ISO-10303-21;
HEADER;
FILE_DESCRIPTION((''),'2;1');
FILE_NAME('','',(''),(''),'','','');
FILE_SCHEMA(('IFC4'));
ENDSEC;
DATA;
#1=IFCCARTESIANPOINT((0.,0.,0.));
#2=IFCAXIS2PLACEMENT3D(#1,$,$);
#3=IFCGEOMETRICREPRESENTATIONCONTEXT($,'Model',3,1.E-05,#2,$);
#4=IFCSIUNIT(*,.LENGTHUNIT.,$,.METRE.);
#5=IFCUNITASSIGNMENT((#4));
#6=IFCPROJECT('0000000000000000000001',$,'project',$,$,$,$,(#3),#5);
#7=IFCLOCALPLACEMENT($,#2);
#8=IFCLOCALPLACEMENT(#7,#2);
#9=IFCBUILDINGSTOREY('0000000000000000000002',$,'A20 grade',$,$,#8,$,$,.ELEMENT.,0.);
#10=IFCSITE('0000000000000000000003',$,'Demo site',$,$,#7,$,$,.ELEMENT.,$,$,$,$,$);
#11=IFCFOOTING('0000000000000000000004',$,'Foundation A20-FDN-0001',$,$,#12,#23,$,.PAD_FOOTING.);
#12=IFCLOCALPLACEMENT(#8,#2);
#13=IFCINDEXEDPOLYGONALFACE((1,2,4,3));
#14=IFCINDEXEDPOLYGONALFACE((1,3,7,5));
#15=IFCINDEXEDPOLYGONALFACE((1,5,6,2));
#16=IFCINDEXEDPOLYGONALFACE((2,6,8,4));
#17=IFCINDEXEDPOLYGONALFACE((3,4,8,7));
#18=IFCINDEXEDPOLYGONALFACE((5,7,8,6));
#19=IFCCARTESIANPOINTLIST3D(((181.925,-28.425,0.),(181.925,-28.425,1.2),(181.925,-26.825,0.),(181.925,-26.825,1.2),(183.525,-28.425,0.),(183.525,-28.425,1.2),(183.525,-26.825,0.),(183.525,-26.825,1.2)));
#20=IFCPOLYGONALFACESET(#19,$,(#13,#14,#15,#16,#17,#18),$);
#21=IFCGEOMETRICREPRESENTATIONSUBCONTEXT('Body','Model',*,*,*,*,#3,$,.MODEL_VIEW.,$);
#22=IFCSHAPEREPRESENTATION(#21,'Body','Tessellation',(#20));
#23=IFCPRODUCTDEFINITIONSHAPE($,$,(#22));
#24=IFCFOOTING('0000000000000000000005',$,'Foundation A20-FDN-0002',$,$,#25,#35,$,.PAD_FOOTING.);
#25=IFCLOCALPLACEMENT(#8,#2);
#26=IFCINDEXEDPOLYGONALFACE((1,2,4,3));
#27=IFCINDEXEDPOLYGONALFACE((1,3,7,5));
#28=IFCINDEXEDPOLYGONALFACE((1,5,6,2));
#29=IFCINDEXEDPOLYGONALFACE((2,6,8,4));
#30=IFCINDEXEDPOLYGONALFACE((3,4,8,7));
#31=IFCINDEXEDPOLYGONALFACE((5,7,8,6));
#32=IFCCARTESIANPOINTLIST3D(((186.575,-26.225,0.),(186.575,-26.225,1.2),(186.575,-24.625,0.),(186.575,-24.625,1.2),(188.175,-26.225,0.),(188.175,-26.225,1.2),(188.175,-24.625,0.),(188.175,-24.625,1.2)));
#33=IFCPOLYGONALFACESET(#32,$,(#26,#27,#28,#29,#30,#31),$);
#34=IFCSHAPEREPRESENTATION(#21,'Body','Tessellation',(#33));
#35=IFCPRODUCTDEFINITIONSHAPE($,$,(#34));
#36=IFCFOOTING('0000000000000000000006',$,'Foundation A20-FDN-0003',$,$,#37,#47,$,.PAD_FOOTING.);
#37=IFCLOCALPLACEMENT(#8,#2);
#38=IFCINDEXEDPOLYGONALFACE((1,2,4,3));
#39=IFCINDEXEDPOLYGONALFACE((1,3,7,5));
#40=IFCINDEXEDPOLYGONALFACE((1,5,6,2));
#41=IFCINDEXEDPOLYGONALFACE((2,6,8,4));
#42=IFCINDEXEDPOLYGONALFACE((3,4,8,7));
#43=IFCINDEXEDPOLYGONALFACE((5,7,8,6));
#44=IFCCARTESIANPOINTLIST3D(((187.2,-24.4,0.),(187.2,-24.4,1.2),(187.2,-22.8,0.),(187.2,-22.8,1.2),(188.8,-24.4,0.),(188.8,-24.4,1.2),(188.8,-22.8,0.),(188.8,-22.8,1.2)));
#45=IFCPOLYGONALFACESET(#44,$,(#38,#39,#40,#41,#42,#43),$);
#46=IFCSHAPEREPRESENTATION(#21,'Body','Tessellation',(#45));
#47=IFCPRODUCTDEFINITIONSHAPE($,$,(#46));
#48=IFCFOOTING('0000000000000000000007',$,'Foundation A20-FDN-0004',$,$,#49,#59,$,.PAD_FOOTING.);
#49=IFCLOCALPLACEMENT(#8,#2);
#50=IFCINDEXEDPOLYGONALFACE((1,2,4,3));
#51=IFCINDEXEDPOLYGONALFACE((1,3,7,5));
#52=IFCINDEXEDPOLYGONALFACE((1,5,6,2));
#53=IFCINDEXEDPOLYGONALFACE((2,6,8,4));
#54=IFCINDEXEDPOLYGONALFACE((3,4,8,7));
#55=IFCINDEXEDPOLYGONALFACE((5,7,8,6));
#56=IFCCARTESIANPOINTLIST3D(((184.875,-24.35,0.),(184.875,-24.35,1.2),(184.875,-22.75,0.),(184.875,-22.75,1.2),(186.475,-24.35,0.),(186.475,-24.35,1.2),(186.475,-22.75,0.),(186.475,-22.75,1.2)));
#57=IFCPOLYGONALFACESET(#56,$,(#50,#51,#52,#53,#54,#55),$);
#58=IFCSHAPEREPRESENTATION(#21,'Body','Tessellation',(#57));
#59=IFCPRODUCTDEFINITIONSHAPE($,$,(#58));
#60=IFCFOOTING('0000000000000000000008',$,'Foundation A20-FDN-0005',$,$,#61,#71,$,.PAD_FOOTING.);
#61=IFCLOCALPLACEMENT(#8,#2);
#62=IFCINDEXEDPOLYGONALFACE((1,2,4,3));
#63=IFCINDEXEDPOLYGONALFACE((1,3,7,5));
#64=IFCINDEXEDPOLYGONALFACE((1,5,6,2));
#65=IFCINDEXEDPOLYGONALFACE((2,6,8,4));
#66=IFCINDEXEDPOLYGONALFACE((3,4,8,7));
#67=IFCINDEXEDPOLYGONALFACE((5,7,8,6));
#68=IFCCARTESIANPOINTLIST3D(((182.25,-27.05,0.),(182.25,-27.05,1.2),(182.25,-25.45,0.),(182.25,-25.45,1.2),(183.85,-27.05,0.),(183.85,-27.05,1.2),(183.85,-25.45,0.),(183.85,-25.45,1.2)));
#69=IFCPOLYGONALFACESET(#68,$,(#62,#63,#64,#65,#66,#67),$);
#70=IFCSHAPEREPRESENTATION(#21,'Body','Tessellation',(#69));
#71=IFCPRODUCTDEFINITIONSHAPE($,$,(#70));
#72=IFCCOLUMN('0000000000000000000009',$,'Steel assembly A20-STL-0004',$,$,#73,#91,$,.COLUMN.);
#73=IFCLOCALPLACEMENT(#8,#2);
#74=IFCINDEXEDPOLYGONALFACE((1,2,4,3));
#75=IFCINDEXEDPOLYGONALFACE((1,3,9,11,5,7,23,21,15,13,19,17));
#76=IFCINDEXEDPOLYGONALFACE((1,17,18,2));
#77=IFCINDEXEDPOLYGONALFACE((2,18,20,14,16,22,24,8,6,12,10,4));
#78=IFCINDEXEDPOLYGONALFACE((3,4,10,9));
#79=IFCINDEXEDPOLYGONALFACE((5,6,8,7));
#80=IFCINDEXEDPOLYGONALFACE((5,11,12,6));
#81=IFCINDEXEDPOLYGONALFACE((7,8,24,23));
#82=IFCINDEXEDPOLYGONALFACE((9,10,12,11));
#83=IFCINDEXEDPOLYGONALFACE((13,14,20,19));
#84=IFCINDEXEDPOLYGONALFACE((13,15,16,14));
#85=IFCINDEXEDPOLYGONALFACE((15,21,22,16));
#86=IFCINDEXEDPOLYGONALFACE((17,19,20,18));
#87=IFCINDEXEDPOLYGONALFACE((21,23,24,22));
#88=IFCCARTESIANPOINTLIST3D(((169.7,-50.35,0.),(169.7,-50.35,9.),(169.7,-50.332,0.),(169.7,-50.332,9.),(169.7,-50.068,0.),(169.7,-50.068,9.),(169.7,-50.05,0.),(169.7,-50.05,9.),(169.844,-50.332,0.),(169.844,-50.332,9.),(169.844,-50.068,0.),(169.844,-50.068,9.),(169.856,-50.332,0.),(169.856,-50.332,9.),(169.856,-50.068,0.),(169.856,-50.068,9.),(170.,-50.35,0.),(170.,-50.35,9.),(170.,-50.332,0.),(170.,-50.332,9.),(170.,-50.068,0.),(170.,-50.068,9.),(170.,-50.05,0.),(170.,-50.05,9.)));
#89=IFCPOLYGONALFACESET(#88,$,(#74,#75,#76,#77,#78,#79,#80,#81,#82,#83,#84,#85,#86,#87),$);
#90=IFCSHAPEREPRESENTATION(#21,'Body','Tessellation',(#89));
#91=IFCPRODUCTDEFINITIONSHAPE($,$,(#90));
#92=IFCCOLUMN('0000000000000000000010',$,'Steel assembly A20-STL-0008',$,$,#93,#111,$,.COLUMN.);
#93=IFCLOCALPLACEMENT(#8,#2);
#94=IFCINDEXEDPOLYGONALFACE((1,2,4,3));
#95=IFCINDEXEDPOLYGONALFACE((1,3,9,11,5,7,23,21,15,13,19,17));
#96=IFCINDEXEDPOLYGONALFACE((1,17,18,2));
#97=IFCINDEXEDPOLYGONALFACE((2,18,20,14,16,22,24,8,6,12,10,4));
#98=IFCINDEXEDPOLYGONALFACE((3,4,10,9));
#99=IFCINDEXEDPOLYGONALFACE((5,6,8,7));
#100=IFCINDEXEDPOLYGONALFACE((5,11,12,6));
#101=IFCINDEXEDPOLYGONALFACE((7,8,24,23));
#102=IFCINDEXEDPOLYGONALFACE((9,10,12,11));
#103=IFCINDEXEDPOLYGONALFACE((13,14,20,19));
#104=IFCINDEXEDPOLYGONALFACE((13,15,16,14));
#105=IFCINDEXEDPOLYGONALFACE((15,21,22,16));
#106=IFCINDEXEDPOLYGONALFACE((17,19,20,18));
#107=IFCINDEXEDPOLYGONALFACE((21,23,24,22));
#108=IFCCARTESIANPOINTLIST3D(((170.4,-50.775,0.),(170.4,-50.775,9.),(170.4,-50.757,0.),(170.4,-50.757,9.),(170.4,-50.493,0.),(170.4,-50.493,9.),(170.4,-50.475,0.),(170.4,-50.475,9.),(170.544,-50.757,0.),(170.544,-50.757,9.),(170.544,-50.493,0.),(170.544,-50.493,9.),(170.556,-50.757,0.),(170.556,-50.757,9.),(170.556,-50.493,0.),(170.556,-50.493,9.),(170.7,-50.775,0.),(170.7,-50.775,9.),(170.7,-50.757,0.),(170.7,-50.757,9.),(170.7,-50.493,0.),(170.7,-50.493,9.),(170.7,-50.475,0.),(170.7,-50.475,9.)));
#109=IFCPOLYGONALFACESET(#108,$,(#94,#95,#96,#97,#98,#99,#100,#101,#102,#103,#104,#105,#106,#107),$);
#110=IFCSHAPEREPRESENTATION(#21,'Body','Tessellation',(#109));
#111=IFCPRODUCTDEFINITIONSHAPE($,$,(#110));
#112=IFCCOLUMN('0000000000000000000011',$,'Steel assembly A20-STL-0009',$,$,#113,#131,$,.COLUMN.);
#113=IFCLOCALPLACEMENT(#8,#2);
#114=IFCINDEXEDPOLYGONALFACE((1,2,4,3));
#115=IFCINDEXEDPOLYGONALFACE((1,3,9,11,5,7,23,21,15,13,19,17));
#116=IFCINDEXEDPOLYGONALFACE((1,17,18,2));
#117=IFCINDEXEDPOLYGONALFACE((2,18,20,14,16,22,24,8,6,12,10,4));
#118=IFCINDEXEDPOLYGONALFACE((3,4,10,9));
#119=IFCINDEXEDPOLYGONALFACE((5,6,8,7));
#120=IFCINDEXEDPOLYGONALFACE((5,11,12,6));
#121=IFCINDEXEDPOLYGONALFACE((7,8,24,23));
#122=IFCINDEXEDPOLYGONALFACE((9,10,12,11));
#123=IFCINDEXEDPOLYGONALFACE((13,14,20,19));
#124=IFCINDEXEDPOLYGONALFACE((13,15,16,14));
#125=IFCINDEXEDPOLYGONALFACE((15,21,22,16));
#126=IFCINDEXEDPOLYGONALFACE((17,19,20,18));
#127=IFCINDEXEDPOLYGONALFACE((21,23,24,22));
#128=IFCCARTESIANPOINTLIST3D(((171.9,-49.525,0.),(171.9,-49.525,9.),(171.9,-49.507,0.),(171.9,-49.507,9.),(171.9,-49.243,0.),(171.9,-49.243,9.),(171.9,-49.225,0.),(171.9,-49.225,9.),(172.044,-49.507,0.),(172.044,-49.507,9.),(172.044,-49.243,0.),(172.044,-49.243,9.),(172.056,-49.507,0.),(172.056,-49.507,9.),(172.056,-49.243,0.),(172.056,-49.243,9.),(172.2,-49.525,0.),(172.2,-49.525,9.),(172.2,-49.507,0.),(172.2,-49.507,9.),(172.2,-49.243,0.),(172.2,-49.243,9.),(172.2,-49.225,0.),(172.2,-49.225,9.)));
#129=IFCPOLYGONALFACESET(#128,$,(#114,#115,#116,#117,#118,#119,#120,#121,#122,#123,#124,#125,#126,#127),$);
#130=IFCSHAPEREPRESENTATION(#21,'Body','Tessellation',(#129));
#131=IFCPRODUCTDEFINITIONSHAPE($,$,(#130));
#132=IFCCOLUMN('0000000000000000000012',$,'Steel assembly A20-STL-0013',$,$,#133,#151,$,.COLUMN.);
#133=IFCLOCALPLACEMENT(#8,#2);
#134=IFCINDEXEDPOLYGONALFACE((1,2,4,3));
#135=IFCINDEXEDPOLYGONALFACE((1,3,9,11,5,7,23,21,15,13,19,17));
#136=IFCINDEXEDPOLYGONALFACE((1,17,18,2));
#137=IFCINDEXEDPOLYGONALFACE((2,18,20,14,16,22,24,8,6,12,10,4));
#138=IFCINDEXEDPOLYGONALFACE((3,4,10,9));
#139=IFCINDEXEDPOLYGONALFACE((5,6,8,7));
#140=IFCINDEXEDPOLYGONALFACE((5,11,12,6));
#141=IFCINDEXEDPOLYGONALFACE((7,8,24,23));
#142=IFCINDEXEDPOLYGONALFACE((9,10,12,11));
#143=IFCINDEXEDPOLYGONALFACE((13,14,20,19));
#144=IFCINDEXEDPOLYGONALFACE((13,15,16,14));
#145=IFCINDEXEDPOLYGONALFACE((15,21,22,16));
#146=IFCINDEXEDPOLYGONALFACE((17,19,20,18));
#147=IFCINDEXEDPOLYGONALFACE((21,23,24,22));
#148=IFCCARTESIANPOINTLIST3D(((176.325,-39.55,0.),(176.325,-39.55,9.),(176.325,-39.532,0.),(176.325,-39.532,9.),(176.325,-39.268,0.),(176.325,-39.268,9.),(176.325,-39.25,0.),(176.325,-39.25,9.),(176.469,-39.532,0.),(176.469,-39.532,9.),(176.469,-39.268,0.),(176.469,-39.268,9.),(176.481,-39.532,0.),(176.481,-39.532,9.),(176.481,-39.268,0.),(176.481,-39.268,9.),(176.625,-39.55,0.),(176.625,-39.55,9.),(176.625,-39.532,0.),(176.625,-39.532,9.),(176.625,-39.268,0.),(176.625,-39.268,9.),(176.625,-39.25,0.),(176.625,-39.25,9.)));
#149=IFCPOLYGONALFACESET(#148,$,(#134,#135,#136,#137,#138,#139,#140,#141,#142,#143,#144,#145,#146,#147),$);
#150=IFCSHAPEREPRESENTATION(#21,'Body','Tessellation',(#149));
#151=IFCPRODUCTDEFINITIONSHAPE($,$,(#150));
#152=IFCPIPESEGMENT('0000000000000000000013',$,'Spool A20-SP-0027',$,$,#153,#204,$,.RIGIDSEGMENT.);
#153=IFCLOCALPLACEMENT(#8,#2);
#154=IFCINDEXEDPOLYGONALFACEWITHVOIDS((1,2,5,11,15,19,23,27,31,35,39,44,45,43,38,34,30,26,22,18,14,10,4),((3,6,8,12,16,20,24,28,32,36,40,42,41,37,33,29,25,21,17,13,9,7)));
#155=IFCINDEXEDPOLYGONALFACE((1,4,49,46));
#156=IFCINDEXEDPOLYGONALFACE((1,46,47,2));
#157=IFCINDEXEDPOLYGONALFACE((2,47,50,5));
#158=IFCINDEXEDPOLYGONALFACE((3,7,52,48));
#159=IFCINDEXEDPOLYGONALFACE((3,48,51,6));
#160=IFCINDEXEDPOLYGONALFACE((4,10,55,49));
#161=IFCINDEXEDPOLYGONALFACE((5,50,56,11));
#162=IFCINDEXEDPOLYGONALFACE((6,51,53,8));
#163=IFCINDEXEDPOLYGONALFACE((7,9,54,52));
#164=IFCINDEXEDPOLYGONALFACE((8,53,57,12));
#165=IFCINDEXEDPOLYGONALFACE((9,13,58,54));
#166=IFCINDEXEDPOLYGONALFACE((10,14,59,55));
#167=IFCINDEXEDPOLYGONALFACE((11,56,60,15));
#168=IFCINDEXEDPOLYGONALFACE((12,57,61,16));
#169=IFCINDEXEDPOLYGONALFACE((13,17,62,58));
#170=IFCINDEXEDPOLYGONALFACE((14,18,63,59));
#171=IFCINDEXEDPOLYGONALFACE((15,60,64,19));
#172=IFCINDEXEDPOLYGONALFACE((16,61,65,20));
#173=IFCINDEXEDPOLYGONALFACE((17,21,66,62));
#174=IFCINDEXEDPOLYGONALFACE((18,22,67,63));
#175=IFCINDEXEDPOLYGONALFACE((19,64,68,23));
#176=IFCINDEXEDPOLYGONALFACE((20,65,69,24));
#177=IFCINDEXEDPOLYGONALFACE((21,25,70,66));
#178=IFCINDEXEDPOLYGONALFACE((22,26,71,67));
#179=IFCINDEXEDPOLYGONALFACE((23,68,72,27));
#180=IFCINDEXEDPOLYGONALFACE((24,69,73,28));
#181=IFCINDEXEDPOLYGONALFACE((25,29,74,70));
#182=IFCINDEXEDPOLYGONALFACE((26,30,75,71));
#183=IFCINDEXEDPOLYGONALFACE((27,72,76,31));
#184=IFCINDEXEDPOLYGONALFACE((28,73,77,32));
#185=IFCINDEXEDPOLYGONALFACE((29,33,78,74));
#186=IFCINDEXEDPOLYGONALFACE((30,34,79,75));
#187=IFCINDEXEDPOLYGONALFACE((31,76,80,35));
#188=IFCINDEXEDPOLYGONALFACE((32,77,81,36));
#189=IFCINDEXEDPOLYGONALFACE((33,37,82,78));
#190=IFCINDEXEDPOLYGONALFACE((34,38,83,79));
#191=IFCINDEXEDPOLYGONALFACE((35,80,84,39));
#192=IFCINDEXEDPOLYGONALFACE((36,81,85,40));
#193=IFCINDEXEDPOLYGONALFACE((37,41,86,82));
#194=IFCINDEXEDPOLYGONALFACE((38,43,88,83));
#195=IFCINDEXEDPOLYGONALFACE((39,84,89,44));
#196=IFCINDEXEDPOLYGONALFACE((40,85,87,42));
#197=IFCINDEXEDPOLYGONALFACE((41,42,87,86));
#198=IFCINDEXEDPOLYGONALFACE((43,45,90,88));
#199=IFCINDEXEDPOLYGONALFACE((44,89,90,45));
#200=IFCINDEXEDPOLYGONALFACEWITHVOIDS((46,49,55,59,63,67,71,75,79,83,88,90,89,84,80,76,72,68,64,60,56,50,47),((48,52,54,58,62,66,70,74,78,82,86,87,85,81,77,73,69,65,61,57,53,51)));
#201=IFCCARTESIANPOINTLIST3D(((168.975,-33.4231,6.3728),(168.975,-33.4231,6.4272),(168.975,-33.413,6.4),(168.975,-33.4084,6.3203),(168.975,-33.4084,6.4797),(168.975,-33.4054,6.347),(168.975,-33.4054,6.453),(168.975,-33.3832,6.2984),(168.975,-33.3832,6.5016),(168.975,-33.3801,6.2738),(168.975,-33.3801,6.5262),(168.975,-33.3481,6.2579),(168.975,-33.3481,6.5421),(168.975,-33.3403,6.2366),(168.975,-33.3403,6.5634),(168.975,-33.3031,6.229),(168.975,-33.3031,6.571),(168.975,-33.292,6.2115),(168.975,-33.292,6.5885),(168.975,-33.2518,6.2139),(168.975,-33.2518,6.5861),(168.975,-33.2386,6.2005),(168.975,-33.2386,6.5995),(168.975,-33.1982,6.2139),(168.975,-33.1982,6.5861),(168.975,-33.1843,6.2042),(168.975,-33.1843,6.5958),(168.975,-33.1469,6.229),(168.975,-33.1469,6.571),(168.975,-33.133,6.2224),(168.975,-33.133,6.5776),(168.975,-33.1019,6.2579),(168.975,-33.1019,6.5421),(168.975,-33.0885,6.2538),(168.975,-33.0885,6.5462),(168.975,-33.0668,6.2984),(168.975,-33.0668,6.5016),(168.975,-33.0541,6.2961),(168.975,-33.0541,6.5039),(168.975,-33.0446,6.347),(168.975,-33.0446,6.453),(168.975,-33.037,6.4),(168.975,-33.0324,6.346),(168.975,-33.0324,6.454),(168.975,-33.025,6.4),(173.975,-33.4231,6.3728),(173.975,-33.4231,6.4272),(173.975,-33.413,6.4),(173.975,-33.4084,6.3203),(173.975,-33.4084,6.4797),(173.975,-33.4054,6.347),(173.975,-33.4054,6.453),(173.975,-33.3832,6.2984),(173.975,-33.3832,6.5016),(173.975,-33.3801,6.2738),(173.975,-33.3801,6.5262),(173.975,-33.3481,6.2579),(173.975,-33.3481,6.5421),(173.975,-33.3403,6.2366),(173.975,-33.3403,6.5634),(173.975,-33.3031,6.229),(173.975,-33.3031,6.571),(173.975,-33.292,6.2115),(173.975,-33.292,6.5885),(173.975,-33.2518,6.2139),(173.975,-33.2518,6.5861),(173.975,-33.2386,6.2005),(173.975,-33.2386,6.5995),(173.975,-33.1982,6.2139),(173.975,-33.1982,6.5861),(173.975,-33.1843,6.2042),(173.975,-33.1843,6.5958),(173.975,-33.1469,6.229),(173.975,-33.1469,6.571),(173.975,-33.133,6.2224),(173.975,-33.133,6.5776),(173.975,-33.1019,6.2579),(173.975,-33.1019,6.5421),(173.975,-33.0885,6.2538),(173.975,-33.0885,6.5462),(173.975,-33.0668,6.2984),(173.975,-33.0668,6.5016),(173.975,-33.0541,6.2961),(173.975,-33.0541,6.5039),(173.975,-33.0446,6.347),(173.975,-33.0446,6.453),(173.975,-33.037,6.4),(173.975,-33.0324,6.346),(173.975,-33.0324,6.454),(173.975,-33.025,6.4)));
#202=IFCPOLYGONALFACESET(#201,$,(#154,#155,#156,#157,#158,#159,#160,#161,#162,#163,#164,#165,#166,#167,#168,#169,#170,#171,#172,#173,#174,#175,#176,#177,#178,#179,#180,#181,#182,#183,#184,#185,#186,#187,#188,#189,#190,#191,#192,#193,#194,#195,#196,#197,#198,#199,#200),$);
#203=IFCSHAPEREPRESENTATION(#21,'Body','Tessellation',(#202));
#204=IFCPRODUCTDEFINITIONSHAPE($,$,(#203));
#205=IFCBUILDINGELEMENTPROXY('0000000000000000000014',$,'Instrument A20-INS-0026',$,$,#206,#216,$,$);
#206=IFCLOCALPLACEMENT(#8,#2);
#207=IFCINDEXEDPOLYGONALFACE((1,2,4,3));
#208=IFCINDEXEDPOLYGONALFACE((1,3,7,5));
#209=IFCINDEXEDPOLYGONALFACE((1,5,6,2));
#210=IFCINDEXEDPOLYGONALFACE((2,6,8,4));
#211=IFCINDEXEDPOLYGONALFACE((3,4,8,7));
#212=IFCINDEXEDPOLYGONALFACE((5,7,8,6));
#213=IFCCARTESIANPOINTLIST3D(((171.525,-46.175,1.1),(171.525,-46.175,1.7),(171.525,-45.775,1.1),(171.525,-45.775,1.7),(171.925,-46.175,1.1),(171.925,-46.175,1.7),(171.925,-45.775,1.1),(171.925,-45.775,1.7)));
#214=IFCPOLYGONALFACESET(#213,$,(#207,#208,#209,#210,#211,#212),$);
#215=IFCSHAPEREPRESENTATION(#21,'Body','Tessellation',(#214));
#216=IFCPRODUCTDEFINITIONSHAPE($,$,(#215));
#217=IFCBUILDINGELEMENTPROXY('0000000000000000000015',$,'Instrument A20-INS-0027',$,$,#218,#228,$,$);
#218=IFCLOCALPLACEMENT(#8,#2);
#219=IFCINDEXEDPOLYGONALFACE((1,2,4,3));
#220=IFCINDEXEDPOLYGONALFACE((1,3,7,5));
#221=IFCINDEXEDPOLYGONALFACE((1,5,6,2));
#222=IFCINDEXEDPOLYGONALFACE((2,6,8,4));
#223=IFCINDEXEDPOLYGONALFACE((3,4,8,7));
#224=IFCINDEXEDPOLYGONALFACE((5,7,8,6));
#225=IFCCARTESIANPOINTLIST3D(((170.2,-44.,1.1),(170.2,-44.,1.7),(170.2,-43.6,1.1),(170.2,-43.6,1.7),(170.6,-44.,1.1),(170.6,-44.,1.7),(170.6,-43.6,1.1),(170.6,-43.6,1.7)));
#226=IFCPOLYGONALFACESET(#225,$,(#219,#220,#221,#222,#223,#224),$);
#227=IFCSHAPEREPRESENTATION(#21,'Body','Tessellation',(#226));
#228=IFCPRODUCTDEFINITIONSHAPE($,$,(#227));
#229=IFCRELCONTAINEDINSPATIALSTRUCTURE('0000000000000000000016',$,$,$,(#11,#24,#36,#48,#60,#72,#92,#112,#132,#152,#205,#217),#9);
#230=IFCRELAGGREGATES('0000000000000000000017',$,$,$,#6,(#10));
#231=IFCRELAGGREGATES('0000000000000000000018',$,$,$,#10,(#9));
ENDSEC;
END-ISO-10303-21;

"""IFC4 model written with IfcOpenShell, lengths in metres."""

from ifc_helpers import new_model, si_unit, frame, origin, place, context, subcontext, project, spatial, rectangle, hollow_circle, i_section, extrude, element, save


model = new_model("IFC4")

# Units and contexts
model_context = context("Model", 3, precision=1e-05, world=origin())
body_context = subcontext(model_context, "Body", "Model", "MODEL_VIEW")
ifc_project = project(units=[si_unit("LENGTHUNIT", "METRE")], contexts=[model_context])

# Site, storey
site_placement = place(None, origin())
site = spatial("IfcSite", under=ifc_project, at=site_placement, Name="Demo site", CompositionType="ELEMENT")
storey_placement = place(site_placement, origin())
storey = spatial("IfcBuildingStorey", under=site, at=storey_placement, Name="A20 grade", CompositionType="ELEMENT", Elevation=0.0)

# Footings
for number, where, name in (
    (1, (182.725, -27.625, 0.0), "Foundation A20-FDN-0001"),
    (2, (187.375, -25.425, 0.0), "Foundation A20-FDN-0002"),
    (3, (188.0, -23.6, 0.0), "Foundation A20-FDN-0003"),
    (4, (185.675, -23.55, 0.0), "Foundation A20-FDN-0004"),
    (5, (183.05, -26.25, 0.0), "Foundation A20-FDN-0005"),
):
    element("IfcFooting", number, at=place(storey_placement, frame(where)), inside=storey, Name=name, PredefinedType="PAD_FOOTING", context=body_context, shape_type="SweptSolid", body=[
        extrude(rectangle(XDim=1.6, YDim=1.6), origin(), (0.0, 0.0, 1.0), 1.2),
    ])

# Columns
for number, where, name in (
    (6, (169.85, -50.2, 0.0), "Steel assembly A20-STL-0004"),
    (7, (170.55, -50.625, 0.0), "Steel assembly A20-STL-0008"),
    (8, (172.05, -49.375, 0.0), "Steel assembly A20-STL-0009"),
    (9, (176.475, -39.4, 0.0), "Steel assembly A20-STL-0013"),
):
    element("IfcColumn", number, at=place(storey_placement, frame(where)), inside=storey, Name=name, PredefinedType="COLUMN", context=body_context, shape_type="SweptSolid", body=[
        extrude(i_section(OverallWidth=0.3, OverallDepth=0.3, WebThickness=0.012, FlangeThickness=0.018), origin(), (0.0, 0.0, 1.0), 9.0),
    ])

# Pipe segment
pipe_segment_placement = place(storey_placement, frame((168.975, -33.225, 6.4)))
element("IfcPipeSegment", 10, at=pipe_segment_placement, inside=storey, Name="Spool A20-SP-0027", PredefinedType="RIGIDSEGMENT", context=body_context, shape_type="SweptSolid", body=[
    extrude(hollow_circle(Radius=0.2, WallThickness=0.012), frame((0.0, 0.0, 0.0), z_axis=(1.0, 0.0, 0.0), x_axis=(0.0, 1.0, 0.0)), (0.0, 0.0, 1.0), 5.0),
])

# Building element proxies
for number, where, name in (
    (11, (171.725, -45.975, 1.1), "Instrument A20-INS-0026"),
    (12, (170.4, -43.8, 1.1), "Instrument A20-INS-0027"),
):
    element("IfcBuildingElementProxy", number, at=place(storey_placement, frame(where)), inside=storey, Name=name, context=body_context, shape_type="SweptSolid", body=[
        extrude(rectangle(XDim=0.4, YDim=0.4), origin(), (0.0, 0.0, 1.0), 0.6),
    ])

save(model, "model.ifc")
